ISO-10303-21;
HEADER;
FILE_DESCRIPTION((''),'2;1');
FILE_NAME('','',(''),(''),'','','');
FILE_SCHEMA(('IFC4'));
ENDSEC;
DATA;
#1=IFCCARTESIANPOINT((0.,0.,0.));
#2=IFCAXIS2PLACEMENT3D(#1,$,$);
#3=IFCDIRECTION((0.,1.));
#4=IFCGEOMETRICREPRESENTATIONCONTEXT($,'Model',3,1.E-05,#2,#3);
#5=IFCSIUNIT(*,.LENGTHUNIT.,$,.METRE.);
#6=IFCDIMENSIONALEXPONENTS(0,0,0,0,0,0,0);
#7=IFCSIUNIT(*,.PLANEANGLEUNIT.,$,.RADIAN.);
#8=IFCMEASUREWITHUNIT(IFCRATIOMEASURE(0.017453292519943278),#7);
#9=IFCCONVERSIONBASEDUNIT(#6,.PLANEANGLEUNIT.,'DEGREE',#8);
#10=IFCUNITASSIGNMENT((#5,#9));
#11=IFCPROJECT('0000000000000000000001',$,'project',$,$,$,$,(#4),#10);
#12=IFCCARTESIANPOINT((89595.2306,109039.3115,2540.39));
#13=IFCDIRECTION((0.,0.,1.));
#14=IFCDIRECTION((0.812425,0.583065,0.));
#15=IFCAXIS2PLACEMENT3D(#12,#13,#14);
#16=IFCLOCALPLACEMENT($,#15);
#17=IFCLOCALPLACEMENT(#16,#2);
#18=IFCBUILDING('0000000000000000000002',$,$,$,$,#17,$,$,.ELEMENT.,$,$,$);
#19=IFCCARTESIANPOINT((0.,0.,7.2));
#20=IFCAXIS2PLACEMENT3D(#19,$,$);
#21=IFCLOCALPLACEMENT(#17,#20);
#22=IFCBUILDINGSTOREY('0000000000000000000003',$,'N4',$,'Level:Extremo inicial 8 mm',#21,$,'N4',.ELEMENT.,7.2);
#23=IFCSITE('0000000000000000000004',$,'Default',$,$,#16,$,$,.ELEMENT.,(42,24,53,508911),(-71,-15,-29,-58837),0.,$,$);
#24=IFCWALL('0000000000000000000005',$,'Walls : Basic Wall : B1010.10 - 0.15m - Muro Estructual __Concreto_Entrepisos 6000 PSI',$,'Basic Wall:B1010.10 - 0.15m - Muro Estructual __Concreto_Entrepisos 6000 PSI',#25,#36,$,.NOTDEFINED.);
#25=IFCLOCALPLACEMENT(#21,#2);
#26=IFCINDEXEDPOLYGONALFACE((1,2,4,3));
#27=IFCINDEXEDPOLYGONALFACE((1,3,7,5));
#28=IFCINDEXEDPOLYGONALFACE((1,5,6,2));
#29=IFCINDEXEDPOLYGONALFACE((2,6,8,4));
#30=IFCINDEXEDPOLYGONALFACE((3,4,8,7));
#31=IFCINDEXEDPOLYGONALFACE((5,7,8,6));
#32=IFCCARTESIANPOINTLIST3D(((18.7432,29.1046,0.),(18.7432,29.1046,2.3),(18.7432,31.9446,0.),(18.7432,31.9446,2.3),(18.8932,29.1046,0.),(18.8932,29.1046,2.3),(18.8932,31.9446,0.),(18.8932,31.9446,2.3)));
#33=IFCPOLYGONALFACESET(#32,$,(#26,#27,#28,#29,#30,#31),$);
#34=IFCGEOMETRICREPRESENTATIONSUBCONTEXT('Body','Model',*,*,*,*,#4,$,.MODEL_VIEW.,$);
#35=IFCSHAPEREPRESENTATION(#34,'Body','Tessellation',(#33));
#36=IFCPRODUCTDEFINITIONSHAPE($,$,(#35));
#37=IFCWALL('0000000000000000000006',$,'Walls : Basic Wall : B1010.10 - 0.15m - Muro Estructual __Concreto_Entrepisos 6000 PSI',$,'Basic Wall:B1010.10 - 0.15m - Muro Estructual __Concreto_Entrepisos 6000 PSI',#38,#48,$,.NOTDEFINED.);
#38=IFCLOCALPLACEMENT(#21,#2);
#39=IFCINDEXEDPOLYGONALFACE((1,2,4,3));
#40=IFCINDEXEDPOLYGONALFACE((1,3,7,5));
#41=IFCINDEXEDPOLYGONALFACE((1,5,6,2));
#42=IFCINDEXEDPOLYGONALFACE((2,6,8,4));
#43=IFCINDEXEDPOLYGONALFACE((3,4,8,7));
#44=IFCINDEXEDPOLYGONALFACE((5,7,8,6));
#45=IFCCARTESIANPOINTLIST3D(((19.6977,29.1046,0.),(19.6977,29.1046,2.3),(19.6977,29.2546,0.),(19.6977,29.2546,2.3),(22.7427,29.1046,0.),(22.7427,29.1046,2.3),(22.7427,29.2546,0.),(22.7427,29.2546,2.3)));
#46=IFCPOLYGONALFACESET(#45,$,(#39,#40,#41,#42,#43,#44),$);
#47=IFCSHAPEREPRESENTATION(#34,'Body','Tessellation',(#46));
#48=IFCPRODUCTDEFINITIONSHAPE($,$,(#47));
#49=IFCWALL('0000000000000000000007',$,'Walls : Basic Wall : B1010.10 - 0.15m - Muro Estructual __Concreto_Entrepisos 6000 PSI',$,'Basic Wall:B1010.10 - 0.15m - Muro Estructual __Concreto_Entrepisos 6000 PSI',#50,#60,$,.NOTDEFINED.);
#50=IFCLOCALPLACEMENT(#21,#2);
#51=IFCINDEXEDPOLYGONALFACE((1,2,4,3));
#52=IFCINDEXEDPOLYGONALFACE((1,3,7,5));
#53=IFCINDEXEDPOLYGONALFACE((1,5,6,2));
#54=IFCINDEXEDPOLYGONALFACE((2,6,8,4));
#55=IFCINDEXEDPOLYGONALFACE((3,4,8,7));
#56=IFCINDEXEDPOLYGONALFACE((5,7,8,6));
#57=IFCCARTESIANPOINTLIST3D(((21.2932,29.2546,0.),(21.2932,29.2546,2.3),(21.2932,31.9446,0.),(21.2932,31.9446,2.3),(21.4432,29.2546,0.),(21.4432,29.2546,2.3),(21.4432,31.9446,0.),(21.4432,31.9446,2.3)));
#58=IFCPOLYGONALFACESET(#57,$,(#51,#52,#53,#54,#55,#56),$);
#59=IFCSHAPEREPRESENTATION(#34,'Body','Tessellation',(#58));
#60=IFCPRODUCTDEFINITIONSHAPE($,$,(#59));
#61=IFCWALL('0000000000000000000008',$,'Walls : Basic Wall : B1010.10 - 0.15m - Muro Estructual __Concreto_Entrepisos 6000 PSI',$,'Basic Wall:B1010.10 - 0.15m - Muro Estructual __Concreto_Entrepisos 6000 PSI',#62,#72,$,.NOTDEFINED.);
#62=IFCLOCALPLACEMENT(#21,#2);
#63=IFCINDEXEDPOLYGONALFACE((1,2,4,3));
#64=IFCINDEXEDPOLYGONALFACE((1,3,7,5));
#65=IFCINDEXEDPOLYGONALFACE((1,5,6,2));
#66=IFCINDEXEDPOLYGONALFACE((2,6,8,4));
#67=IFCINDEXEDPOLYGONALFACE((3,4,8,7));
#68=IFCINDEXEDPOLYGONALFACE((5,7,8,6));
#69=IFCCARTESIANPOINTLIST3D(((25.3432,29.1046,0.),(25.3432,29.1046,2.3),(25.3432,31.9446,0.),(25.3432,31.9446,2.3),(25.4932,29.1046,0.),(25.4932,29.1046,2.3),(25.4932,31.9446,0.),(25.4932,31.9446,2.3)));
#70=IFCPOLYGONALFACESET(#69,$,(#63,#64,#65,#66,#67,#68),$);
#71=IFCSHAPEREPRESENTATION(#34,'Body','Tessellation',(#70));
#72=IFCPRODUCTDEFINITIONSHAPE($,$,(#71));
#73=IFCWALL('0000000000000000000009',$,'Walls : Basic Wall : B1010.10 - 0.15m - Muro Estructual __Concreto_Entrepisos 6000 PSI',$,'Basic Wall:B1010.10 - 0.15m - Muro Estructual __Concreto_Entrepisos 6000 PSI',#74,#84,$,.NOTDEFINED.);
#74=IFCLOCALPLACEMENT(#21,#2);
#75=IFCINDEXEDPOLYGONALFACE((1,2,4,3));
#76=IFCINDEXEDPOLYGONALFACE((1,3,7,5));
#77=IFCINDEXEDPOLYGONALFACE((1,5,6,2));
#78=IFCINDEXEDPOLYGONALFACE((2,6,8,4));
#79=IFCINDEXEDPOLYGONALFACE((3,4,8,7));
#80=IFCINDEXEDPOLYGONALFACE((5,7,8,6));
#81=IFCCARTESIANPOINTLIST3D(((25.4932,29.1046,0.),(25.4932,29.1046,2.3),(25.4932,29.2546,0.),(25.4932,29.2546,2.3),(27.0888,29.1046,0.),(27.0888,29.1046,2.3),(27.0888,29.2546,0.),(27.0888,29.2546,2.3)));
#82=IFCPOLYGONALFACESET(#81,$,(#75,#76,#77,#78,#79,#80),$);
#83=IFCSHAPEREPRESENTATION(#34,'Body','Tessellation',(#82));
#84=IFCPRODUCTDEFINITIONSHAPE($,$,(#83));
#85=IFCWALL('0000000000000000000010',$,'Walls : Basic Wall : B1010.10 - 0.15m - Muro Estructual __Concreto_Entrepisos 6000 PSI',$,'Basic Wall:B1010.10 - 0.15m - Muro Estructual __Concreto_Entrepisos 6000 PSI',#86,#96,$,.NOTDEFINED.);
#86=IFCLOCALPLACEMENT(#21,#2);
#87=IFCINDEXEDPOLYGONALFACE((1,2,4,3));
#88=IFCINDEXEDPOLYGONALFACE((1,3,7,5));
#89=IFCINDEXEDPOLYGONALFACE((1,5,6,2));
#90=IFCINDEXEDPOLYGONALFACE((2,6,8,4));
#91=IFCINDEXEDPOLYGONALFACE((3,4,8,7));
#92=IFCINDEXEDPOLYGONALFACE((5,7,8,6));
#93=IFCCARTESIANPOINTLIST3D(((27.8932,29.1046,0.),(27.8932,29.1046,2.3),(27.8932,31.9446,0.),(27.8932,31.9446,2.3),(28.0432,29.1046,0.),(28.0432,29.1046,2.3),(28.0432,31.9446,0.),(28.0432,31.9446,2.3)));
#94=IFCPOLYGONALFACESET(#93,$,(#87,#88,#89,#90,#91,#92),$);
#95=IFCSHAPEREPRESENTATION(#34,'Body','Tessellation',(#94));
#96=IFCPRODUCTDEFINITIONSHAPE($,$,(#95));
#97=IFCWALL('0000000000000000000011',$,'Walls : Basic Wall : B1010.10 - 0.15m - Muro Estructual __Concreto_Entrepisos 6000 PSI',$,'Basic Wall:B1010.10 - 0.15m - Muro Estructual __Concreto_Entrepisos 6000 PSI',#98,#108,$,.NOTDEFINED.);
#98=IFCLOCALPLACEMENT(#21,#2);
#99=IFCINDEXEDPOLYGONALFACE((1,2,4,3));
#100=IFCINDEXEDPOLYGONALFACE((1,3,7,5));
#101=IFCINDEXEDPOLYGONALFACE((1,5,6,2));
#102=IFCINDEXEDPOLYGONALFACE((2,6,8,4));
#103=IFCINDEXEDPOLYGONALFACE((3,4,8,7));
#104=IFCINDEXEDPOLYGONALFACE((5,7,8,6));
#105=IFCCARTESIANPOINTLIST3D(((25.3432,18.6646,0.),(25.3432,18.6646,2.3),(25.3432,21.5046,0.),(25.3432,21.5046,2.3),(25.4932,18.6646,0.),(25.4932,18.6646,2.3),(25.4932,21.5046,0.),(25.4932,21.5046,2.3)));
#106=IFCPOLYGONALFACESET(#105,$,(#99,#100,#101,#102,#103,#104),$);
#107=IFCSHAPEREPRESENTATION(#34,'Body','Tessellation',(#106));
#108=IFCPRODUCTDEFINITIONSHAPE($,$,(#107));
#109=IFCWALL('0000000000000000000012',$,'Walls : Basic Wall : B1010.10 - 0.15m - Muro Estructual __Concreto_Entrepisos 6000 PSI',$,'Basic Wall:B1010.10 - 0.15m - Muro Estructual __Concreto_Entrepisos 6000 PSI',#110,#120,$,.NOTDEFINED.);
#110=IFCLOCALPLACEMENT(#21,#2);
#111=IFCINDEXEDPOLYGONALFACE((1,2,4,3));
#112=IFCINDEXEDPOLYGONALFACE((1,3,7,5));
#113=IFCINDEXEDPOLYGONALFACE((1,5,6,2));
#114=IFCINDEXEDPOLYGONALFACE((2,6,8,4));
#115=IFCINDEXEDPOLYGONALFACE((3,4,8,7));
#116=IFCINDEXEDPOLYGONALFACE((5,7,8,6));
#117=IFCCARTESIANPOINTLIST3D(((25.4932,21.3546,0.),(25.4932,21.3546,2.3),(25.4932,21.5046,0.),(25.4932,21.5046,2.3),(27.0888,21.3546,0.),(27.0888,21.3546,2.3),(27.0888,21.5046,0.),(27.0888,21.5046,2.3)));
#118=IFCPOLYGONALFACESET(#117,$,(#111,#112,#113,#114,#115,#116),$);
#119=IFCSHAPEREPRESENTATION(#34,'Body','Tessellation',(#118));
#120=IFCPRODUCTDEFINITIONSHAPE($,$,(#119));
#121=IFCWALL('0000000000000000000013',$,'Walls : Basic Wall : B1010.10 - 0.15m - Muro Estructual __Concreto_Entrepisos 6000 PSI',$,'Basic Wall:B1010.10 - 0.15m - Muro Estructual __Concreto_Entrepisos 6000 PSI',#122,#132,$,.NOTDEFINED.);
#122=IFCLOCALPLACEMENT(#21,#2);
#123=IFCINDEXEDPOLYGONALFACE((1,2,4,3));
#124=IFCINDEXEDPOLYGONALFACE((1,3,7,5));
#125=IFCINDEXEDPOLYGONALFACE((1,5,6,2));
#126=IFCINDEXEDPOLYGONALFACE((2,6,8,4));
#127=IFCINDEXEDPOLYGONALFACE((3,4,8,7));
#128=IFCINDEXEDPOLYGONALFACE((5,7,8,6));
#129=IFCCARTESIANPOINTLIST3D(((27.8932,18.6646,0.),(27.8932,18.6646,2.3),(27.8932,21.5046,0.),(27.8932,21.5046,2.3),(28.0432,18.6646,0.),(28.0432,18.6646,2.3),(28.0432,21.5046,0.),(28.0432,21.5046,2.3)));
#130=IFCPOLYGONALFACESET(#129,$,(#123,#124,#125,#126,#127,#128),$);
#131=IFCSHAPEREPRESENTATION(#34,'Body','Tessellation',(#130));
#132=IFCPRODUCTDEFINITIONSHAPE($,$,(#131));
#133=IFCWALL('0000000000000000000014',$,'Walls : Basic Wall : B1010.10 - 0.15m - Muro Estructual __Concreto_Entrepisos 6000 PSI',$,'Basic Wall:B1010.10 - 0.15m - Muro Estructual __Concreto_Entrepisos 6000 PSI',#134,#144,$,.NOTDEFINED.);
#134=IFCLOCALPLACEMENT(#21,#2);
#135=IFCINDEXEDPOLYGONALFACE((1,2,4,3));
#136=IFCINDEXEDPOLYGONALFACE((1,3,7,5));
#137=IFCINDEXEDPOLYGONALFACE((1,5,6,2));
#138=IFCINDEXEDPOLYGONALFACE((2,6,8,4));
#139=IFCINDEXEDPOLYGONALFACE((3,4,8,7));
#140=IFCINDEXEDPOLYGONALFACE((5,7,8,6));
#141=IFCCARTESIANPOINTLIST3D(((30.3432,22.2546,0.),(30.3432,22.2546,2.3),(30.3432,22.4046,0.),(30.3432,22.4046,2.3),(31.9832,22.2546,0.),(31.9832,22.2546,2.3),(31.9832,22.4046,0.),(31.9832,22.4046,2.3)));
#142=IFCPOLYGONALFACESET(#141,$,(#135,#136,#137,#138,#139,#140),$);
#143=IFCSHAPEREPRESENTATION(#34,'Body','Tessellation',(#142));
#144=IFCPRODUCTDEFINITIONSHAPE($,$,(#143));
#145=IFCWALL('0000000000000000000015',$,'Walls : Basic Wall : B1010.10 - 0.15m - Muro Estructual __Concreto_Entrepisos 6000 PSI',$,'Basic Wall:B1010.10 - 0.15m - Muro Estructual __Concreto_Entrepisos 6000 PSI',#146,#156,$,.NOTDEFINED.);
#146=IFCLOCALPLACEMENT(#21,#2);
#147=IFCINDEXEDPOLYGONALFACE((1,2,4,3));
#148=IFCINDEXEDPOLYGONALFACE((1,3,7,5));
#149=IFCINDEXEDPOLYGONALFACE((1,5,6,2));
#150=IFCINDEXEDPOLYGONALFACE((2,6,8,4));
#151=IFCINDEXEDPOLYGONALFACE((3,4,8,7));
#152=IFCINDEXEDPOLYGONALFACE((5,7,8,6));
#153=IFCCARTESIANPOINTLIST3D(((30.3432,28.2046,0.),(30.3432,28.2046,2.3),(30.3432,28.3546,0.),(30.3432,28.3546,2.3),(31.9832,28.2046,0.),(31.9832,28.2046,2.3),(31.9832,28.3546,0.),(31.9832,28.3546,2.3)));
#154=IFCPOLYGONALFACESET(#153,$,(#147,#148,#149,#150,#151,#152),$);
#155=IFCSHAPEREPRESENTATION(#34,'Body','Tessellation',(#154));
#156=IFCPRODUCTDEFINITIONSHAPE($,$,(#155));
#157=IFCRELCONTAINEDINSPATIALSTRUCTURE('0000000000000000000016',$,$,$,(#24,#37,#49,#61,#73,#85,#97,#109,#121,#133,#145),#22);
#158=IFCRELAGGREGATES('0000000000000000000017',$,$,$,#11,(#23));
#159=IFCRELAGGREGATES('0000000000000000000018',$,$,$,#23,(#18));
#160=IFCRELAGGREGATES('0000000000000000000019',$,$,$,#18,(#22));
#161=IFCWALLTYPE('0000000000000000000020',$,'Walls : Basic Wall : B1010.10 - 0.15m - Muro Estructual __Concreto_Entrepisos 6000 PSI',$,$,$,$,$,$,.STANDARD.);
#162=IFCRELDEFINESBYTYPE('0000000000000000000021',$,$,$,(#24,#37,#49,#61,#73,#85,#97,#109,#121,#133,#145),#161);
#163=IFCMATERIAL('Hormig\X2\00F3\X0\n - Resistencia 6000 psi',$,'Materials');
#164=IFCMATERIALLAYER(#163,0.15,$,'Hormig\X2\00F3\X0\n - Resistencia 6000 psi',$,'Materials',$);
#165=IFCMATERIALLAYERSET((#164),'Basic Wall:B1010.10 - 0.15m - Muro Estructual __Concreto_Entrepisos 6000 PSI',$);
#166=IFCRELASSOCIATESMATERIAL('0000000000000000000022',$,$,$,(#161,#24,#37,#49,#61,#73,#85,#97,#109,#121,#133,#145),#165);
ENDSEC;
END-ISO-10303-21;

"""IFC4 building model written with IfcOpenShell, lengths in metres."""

from ifc_helpers import new_model, entity, si_unit, converted_unit, direction, frame, frame_2d, origin, place, context, subcontext, project, spatial, rectangle, extrude, material, layer, layer_set, layer_usage, type_object, element, save


model = new_model("IFC4")

# Units and contexts
model_context = context("Model", 3, precision=1e-05, world=origin(), true_north=direction((0.0, 1.0)))
body_context = subcontext(model_context, "Body", "Model", "MODEL_VIEW")
ifc_project = project(units=[si_unit("LENGTHUNIT", "METRE"), converted_unit("PLANEANGLEUNIT", "DEGREE", entity("IfcRatioMeasure", 0.017453292519943278), si_unit("PLANEANGLEUNIT", "RADIAN"), dimensions=[0, 0, 0, 0, 0, 0, 0])], contexts=[model_context])

# Site, building, storey
site_placement = place(None, frame((89595.2306, 109039.3115, 2540.39), z_axis=(0.0, 0.0, 1.0), x_axis=(0.812425, 0.583065, 0.0)))
site = spatial("IfcSite", under=ifc_project, at=site_placement, Name="Default", CompositionType="ELEMENT", RefLatitude=(42, 24, 53, 508911), RefLongitude=(-71, -15, -29, -58837), RefElevation=0.0)
building_placement = place(site_placement, origin())
building = spatial("IfcBuilding", under=site, at=building_placement, CompositionType="ELEMENT")
storey_placement = place(building_placement, frame((0.0, 0.0, 7.2)))
storey = spatial("IfcBuildingStorey", under=building, at=storey_placement, Name="N4", ObjectType="Level:Extremo inicial 8 mm", LongName="N4", CompositionType="ELEMENT", Elevation=7.2)

# Walls
ifc_material_1 = material(Name="Hormigón - Resistencia 6000 psi", Category="Materials")
ifc_layer_1 = layer(ifc_material_1, 0.15, Name="Hormigón - Resistencia 6000 psi", Category="Materials")
ifc_layer_set_1 = layer_set([ifc_layer_1], Name="Basic Wall:B1010.10 - 0.15m - Muro Estructual __Concreto_Entrepisos 6000 PSI")
wall_type_1 = type_object("IfcWallType", Name="Walls : Basic Wall : B1010.10 - 0.15m - Muro Estructual __Concreto_Entrepisos 6000 PSI", PredefinedType="STANDARD", material=ifc_layer_set_1)
ifc_layer_usage_1 = layer_usage(ifc_layer_set_1, "AXIS2", "NEGATIVE", 0.075)
wall_1_placement = place(storey_placement, frame((18.8182, 31.9446, 0.0), z_axis=(0.0, 0.0, 1.0), x_axis=(0.0, -1.0, 0.0)))
element("IfcWall", 1, at=wall_1_placement, inside=storey, type_object=wall_type_1, material=ifc_layer_usage_1, Name="Walls : Basic Wall : B1010.10 - 0.15m - Muro Estructual __Concreto_Entrepisos 6000 PSI", ObjectType="Basic Wall:B1010.10 - 0.15m - Muro Estructual __Concreto_Entrepisos 6000 PSI", PredefinedType="NOTDEFINED", context=body_context, shape_type="SweptSolid", body=[
    extrude(rectangle(XDim=2.84, YDim=0.15, at=frame_2d((1.42, 0.0), x_axis=(-1.0, 0.0))), origin(), (0.0, 0.0, 1.0), 2.3),
])
ifc_layer_usage_2 = layer_usage(ifc_layer_set_1, "AXIS2", "NEGATIVE", 0.075)
wall_2_placement = place(storey_placement, frame((19.6977, 29.1796, 0.0)))
element("IfcWall", 2, at=wall_2_placement, inside=storey, type_object=wall_type_1, material=ifc_layer_usage_2, Name="Walls : Basic Wall : B1010.10 - 0.15m - Muro Estructual __Concreto_Entrepisos 6000 PSI", ObjectType="Basic Wall:B1010.10 - 0.15m - Muro Estructual __Concreto_Entrepisos 6000 PSI", PredefinedType="NOTDEFINED", context=body_context, shape_type="SweptSolid", body=[
    extrude(rectangle(XDim=3.045, YDim=0.15, at=frame_2d((1.5225, 0.0), x_axis=(-1.0, 0.0))), origin(), (0.0, 0.0, 1.0), 2.3),
])
ifc_layer_usage_3 = layer_usage(ifc_layer_set_1, "AXIS2", "NEGATIVE", 0.075)
wall_3_placement = place(storey_placement, frame((21.3682, 31.9446, 0.0), z_axis=(0.0, 0.0, 1.0), x_axis=(0.0, -1.0, 0.0)))
element("IfcWall", 3, at=wall_3_placement, inside=storey, type_object=wall_type_1, material=ifc_layer_usage_3, Name="Walls : Basic Wall : B1010.10 - 0.15m - Muro Estructual __Concreto_Entrepisos 6000 PSI", ObjectType="Basic Wall:B1010.10 - 0.15m - Muro Estructual __Concreto_Entrepisos 6000 PSI", PredefinedType="NOTDEFINED", context=body_context, shape_type="SweptSolid", body=[
    extrude(rectangle(XDim=2.69, YDim=0.15, at=frame_2d((1.345, 0.0), x_axis=(-1.0, 0.0))), origin(), (0.0, 0.0, 1.0), 2.3),
])
ifc_layer_usage_4 = layer_usage(ifc_layer_set_1, "AXIS2", "NEGATIVE", 0.075)
wall_4_placement = place(storey_placement, frame((25.4182, 31.9446, 0.0), z_axis=(0.0, 0.0, 1.0), x_axis=(0.0, -1.0, 0.0)))
element("IfcWall", 4, at=wall_4_placement, inside=storey, type_object=wall_type_1, material=ifc_layer_usage_4, Name="Walls : Basic Wall : B1010.10 - 0.15m - Muro Estructual __Concreto_Entrepisos 6000 PSI", ObjectType="Basic Wall:B1010.10 - 0.15m - Muro Estructual __Concreto_Entrepisos 6000 PSI", PredefinedType="NOTDEFINED", context=body_context, shape_type="SweptSolid", body=[
    extrude(rectangle(XDim=2.84, YDim=0.15, at=frame_2d((1.42, 0.0), x_axis=(-1.0, 0.0))), origin(), (0.0, 0.0, 1.0), 2.3),
])
ifc_layer_usage_5 = layer_usage(ifc_layer_set_1, "AXIS2", "NEGATIVE", 0.075)
wall_5_placement = place(storey_placement, frame((27.0888, 29.1796, 0.0), z_axis=(0.0, 0.0, 1.0), x_axis=(-1.0, 0.0, 0.0)))
element("IfcWall", 5, at=wall_5_placement, inside=storey, type_object=wall_type_1, material=ifc_layer_usage_5, Name="Walls : Basic Wall : B1010.10 - 0.15m - Muro Estructual __Concreto_Entrepisos 6000 PSI", ObjectType="Basic Wall:B1010.10 - 0.15m - Muro Estructual __Concreto_Entrepisos 6000 PSI", PredefinedType="NOTDEFINED", context=body_context, shape_type="SweptSolid", body=[
    extrude(rectangle(XDim=1.5955, YDim=0.15, at=frame_2d((0.7978, 0.0), x_axis=(-1.0, 0.0))), origin(), (0.0, 0.0, 1.0), 2.3),
])
ifc_layer_usage_6 = layer_usage(ifc_layer_set_1, "AXIS2", "NEGATIVE", 0.075)
wall_6_placement = place(storey_placement, frame((27.9682, 31.9446, 0.0), z_axis=(0.0, 0.0, 1.0), x_axis=(0.0, -1.0, 0.0)))
element("IfcWall", 6, at=wall_6_placement, inside=storey, type_object=wall_type_1, material=ifc_layer_usage_6, Name="Walls : Basic Wall : B1010.10 - 0.15m - Muro Estructual __Concreto_Entrepisos 6000 PSI", ObjectType="Basic Wall:B1010.10 - 0.15m - Muro Estructual __Concreto_Entrepisos 6000 PSI", PredefinedType="NOTDEFINED", context=body_context, shape_type="SweptSolid", body=[
    extrude(rectangle(XDim=2.84, YDim=0.15, at=frame_2d((1.42, 0.0), x_axis=(-1.0, 0.0))), origin(), (0.0, 0.0, 1.0), 2.3),
])
ifc_layer_usage_7 = layer_usage(ifc_layer_set_1, "AXIS2", "NEGATIVE", 0.075)
wall_7_placement = place(storey_placement, frame((25.4182, 18.6646, 0.0), z_axis=(0.0, 0.0, 1.0), x_axis=(0.0, 1.0, 0.0)))
element("IfcWall", 7, at=wall_7_placement, inside=storey, type_object=wall_type_1, material=ifc_layer_usage_7, Name="Walls : Basic Wall : B1010.10 - 0.15m - Muro Estructual __Concreto_Entrepisos 6000 PSI", ObjectType="Basic Wall:B1010.10 - 0.15m - Muro Estructual __Concreto_Entrepisos 6000 PSI", PredefinedType="NOTDEFINED", context=body_context, shape_type="SweptSolid", body=[
    extrude(rectangle(XDim=2.84, YDim=0.15, at=frame_2d((1.42, 0.0), x_axis=(-1.0, 0.0))), origin(), (0.0, 0.0, 1.0), 2.3),
])
ifc_layer_usage_8 = layer_usage(ifc_layer_set_1, "AXIS2", "NEGATIVE", 0.075)
wall_8_placement = place(storey_placement, frame((27.0888, 21.4296, 0.0), z_axis=(0.0, 0.0, 1.0), x_axis=(-1.0, 0.0, 0.0)))
element("IfcWall", 8, at=wall_8_placement, inside=storey, type_object=wall_type_1, material=ifc_layer_usage_8, Name="Walls : Basic Wall : B1010.10 - 0.15m - Muro Estructual __Concreto_Entrepisos 6000 PSI", ObjectType="Basic Wall:B1010.10 - 0.15m - Muro Estructual __Concreto_Entrepisos 6000 PSI", PredefinedType="NOTDEFINED", context=body_context, shape_type="SweptSolid", body=[
    extrude(rectangle(XDim=1.5955, YDim=0.15, at=frame_2d((0.7978, 0.0), x_axis=(-1.0, 0.0))), origin(), (0.0, 0.0, 1.0), 2.3),
])
ifc_layer_usage_9 = layer_usage(ifc_layer_set_1, "AXIS2", "NEGATIVE", 0.075)
wall_9_placement = place(storey_placement, frame((27.9682, 18.6646, 0.0), z_axis=(0.0, 0.0, 1.0), x_axis=(0.0, 1.0, 0.0)))
element("IfcWall", 9, at=wall_9_placement, inside=storey, type_object=wall_type_1, material=ifc_layer_usage_9, Name="Walls : Basic Wall : B1010.10 - 0.15m - Muro Estructual __Concreto_Entrepisos 6000 PSI", ObjectType="Basic Wall:B1010.10 - 0.15m - Muro Estructual __Concreto_Entrepisos 6000 PSI", PredefinedType="NOTDEFINED", context=body_context, shape_type="SweptSolid", body=[
    extrude(rectangle(XDim=2.84, YDim=0.15, at=frame_2d((1.42, 0.0), x_axis=(-1.0, 0.0))), origin(), (0.0, 0.0, 1.0), 2.3),
])
ifc_layer_usage_10 = layer_usage(ifc_layer_set_1, "AXIS2", "NEGATIVE", 0.075)
wall_10_placement = place(storey_placement, frame((31.9832, 22.3296, 0.0), z_axis=(0.0, 0.0, 1.0), x_axis=(-1.0, 0.0, 0.0)))
element("IfcWall", 10, at=wall_10_placement, inside=storey, type_object=wall_type_1, material=ifc_layer_usage_10, Name="Walls : Basic Wall : B1010.10 - 0.15m - Muro Estructual __Concreto_Entrepisos 6000 PSI", ObjectType="Basic Wall:B1010.10 - 0.15m - Muro Estructual __Concreto_Entrepisos 6000 PSI", PredefinedType="NOTDEFINED", context=body_context, shape_type="SweptSolid", body=[
    extrude(rectangle(XDim=1.64, YDim=0.15, at=frame_2d((0.82, 0.0), x_axis=(-1.0, 0.0))), origin(), (0.0, 0.0, 1.0), 2.3),
])
ifc_layer_usage_11 = layer_usage(ifc_layer_set_1, "AXIS2", "POSITIVE", -0.075)
wall_11_placement = place(storey_placement, frame((31.9832, 28.2796, 0.0), z_axis=(0.0, 0.0, 1.0), x_axis=(-1.0, 0.0, 0.0)))
element("IfcWall", 11, at=wall_11_placement, inside=storey, type_object=wall_type_1, material=ifc_layer_usage_11, Name="Walls : Basic Wall : B1010.10 - 0.15m - Muro Estructual __Concreto_Entrepisos 6000 PSI", ObjectType="Basic Wall:B1010.10 - 0.15m - Muro Estructual __Concreto_Entrepisos 6000 PSI", PredefinedType="NOTDEFINED", context=body_context, shape_type="SweptSolid", body=[
    extrude(rectangle(XDim=1.64, YDim=0.15, at=frame_2d((0.82, 0.0), x_axis=(-1.0, 0.0))), origin(), (0.0, 0.0, 1.0), 2.3),
])

save(model, "model.ifc")
